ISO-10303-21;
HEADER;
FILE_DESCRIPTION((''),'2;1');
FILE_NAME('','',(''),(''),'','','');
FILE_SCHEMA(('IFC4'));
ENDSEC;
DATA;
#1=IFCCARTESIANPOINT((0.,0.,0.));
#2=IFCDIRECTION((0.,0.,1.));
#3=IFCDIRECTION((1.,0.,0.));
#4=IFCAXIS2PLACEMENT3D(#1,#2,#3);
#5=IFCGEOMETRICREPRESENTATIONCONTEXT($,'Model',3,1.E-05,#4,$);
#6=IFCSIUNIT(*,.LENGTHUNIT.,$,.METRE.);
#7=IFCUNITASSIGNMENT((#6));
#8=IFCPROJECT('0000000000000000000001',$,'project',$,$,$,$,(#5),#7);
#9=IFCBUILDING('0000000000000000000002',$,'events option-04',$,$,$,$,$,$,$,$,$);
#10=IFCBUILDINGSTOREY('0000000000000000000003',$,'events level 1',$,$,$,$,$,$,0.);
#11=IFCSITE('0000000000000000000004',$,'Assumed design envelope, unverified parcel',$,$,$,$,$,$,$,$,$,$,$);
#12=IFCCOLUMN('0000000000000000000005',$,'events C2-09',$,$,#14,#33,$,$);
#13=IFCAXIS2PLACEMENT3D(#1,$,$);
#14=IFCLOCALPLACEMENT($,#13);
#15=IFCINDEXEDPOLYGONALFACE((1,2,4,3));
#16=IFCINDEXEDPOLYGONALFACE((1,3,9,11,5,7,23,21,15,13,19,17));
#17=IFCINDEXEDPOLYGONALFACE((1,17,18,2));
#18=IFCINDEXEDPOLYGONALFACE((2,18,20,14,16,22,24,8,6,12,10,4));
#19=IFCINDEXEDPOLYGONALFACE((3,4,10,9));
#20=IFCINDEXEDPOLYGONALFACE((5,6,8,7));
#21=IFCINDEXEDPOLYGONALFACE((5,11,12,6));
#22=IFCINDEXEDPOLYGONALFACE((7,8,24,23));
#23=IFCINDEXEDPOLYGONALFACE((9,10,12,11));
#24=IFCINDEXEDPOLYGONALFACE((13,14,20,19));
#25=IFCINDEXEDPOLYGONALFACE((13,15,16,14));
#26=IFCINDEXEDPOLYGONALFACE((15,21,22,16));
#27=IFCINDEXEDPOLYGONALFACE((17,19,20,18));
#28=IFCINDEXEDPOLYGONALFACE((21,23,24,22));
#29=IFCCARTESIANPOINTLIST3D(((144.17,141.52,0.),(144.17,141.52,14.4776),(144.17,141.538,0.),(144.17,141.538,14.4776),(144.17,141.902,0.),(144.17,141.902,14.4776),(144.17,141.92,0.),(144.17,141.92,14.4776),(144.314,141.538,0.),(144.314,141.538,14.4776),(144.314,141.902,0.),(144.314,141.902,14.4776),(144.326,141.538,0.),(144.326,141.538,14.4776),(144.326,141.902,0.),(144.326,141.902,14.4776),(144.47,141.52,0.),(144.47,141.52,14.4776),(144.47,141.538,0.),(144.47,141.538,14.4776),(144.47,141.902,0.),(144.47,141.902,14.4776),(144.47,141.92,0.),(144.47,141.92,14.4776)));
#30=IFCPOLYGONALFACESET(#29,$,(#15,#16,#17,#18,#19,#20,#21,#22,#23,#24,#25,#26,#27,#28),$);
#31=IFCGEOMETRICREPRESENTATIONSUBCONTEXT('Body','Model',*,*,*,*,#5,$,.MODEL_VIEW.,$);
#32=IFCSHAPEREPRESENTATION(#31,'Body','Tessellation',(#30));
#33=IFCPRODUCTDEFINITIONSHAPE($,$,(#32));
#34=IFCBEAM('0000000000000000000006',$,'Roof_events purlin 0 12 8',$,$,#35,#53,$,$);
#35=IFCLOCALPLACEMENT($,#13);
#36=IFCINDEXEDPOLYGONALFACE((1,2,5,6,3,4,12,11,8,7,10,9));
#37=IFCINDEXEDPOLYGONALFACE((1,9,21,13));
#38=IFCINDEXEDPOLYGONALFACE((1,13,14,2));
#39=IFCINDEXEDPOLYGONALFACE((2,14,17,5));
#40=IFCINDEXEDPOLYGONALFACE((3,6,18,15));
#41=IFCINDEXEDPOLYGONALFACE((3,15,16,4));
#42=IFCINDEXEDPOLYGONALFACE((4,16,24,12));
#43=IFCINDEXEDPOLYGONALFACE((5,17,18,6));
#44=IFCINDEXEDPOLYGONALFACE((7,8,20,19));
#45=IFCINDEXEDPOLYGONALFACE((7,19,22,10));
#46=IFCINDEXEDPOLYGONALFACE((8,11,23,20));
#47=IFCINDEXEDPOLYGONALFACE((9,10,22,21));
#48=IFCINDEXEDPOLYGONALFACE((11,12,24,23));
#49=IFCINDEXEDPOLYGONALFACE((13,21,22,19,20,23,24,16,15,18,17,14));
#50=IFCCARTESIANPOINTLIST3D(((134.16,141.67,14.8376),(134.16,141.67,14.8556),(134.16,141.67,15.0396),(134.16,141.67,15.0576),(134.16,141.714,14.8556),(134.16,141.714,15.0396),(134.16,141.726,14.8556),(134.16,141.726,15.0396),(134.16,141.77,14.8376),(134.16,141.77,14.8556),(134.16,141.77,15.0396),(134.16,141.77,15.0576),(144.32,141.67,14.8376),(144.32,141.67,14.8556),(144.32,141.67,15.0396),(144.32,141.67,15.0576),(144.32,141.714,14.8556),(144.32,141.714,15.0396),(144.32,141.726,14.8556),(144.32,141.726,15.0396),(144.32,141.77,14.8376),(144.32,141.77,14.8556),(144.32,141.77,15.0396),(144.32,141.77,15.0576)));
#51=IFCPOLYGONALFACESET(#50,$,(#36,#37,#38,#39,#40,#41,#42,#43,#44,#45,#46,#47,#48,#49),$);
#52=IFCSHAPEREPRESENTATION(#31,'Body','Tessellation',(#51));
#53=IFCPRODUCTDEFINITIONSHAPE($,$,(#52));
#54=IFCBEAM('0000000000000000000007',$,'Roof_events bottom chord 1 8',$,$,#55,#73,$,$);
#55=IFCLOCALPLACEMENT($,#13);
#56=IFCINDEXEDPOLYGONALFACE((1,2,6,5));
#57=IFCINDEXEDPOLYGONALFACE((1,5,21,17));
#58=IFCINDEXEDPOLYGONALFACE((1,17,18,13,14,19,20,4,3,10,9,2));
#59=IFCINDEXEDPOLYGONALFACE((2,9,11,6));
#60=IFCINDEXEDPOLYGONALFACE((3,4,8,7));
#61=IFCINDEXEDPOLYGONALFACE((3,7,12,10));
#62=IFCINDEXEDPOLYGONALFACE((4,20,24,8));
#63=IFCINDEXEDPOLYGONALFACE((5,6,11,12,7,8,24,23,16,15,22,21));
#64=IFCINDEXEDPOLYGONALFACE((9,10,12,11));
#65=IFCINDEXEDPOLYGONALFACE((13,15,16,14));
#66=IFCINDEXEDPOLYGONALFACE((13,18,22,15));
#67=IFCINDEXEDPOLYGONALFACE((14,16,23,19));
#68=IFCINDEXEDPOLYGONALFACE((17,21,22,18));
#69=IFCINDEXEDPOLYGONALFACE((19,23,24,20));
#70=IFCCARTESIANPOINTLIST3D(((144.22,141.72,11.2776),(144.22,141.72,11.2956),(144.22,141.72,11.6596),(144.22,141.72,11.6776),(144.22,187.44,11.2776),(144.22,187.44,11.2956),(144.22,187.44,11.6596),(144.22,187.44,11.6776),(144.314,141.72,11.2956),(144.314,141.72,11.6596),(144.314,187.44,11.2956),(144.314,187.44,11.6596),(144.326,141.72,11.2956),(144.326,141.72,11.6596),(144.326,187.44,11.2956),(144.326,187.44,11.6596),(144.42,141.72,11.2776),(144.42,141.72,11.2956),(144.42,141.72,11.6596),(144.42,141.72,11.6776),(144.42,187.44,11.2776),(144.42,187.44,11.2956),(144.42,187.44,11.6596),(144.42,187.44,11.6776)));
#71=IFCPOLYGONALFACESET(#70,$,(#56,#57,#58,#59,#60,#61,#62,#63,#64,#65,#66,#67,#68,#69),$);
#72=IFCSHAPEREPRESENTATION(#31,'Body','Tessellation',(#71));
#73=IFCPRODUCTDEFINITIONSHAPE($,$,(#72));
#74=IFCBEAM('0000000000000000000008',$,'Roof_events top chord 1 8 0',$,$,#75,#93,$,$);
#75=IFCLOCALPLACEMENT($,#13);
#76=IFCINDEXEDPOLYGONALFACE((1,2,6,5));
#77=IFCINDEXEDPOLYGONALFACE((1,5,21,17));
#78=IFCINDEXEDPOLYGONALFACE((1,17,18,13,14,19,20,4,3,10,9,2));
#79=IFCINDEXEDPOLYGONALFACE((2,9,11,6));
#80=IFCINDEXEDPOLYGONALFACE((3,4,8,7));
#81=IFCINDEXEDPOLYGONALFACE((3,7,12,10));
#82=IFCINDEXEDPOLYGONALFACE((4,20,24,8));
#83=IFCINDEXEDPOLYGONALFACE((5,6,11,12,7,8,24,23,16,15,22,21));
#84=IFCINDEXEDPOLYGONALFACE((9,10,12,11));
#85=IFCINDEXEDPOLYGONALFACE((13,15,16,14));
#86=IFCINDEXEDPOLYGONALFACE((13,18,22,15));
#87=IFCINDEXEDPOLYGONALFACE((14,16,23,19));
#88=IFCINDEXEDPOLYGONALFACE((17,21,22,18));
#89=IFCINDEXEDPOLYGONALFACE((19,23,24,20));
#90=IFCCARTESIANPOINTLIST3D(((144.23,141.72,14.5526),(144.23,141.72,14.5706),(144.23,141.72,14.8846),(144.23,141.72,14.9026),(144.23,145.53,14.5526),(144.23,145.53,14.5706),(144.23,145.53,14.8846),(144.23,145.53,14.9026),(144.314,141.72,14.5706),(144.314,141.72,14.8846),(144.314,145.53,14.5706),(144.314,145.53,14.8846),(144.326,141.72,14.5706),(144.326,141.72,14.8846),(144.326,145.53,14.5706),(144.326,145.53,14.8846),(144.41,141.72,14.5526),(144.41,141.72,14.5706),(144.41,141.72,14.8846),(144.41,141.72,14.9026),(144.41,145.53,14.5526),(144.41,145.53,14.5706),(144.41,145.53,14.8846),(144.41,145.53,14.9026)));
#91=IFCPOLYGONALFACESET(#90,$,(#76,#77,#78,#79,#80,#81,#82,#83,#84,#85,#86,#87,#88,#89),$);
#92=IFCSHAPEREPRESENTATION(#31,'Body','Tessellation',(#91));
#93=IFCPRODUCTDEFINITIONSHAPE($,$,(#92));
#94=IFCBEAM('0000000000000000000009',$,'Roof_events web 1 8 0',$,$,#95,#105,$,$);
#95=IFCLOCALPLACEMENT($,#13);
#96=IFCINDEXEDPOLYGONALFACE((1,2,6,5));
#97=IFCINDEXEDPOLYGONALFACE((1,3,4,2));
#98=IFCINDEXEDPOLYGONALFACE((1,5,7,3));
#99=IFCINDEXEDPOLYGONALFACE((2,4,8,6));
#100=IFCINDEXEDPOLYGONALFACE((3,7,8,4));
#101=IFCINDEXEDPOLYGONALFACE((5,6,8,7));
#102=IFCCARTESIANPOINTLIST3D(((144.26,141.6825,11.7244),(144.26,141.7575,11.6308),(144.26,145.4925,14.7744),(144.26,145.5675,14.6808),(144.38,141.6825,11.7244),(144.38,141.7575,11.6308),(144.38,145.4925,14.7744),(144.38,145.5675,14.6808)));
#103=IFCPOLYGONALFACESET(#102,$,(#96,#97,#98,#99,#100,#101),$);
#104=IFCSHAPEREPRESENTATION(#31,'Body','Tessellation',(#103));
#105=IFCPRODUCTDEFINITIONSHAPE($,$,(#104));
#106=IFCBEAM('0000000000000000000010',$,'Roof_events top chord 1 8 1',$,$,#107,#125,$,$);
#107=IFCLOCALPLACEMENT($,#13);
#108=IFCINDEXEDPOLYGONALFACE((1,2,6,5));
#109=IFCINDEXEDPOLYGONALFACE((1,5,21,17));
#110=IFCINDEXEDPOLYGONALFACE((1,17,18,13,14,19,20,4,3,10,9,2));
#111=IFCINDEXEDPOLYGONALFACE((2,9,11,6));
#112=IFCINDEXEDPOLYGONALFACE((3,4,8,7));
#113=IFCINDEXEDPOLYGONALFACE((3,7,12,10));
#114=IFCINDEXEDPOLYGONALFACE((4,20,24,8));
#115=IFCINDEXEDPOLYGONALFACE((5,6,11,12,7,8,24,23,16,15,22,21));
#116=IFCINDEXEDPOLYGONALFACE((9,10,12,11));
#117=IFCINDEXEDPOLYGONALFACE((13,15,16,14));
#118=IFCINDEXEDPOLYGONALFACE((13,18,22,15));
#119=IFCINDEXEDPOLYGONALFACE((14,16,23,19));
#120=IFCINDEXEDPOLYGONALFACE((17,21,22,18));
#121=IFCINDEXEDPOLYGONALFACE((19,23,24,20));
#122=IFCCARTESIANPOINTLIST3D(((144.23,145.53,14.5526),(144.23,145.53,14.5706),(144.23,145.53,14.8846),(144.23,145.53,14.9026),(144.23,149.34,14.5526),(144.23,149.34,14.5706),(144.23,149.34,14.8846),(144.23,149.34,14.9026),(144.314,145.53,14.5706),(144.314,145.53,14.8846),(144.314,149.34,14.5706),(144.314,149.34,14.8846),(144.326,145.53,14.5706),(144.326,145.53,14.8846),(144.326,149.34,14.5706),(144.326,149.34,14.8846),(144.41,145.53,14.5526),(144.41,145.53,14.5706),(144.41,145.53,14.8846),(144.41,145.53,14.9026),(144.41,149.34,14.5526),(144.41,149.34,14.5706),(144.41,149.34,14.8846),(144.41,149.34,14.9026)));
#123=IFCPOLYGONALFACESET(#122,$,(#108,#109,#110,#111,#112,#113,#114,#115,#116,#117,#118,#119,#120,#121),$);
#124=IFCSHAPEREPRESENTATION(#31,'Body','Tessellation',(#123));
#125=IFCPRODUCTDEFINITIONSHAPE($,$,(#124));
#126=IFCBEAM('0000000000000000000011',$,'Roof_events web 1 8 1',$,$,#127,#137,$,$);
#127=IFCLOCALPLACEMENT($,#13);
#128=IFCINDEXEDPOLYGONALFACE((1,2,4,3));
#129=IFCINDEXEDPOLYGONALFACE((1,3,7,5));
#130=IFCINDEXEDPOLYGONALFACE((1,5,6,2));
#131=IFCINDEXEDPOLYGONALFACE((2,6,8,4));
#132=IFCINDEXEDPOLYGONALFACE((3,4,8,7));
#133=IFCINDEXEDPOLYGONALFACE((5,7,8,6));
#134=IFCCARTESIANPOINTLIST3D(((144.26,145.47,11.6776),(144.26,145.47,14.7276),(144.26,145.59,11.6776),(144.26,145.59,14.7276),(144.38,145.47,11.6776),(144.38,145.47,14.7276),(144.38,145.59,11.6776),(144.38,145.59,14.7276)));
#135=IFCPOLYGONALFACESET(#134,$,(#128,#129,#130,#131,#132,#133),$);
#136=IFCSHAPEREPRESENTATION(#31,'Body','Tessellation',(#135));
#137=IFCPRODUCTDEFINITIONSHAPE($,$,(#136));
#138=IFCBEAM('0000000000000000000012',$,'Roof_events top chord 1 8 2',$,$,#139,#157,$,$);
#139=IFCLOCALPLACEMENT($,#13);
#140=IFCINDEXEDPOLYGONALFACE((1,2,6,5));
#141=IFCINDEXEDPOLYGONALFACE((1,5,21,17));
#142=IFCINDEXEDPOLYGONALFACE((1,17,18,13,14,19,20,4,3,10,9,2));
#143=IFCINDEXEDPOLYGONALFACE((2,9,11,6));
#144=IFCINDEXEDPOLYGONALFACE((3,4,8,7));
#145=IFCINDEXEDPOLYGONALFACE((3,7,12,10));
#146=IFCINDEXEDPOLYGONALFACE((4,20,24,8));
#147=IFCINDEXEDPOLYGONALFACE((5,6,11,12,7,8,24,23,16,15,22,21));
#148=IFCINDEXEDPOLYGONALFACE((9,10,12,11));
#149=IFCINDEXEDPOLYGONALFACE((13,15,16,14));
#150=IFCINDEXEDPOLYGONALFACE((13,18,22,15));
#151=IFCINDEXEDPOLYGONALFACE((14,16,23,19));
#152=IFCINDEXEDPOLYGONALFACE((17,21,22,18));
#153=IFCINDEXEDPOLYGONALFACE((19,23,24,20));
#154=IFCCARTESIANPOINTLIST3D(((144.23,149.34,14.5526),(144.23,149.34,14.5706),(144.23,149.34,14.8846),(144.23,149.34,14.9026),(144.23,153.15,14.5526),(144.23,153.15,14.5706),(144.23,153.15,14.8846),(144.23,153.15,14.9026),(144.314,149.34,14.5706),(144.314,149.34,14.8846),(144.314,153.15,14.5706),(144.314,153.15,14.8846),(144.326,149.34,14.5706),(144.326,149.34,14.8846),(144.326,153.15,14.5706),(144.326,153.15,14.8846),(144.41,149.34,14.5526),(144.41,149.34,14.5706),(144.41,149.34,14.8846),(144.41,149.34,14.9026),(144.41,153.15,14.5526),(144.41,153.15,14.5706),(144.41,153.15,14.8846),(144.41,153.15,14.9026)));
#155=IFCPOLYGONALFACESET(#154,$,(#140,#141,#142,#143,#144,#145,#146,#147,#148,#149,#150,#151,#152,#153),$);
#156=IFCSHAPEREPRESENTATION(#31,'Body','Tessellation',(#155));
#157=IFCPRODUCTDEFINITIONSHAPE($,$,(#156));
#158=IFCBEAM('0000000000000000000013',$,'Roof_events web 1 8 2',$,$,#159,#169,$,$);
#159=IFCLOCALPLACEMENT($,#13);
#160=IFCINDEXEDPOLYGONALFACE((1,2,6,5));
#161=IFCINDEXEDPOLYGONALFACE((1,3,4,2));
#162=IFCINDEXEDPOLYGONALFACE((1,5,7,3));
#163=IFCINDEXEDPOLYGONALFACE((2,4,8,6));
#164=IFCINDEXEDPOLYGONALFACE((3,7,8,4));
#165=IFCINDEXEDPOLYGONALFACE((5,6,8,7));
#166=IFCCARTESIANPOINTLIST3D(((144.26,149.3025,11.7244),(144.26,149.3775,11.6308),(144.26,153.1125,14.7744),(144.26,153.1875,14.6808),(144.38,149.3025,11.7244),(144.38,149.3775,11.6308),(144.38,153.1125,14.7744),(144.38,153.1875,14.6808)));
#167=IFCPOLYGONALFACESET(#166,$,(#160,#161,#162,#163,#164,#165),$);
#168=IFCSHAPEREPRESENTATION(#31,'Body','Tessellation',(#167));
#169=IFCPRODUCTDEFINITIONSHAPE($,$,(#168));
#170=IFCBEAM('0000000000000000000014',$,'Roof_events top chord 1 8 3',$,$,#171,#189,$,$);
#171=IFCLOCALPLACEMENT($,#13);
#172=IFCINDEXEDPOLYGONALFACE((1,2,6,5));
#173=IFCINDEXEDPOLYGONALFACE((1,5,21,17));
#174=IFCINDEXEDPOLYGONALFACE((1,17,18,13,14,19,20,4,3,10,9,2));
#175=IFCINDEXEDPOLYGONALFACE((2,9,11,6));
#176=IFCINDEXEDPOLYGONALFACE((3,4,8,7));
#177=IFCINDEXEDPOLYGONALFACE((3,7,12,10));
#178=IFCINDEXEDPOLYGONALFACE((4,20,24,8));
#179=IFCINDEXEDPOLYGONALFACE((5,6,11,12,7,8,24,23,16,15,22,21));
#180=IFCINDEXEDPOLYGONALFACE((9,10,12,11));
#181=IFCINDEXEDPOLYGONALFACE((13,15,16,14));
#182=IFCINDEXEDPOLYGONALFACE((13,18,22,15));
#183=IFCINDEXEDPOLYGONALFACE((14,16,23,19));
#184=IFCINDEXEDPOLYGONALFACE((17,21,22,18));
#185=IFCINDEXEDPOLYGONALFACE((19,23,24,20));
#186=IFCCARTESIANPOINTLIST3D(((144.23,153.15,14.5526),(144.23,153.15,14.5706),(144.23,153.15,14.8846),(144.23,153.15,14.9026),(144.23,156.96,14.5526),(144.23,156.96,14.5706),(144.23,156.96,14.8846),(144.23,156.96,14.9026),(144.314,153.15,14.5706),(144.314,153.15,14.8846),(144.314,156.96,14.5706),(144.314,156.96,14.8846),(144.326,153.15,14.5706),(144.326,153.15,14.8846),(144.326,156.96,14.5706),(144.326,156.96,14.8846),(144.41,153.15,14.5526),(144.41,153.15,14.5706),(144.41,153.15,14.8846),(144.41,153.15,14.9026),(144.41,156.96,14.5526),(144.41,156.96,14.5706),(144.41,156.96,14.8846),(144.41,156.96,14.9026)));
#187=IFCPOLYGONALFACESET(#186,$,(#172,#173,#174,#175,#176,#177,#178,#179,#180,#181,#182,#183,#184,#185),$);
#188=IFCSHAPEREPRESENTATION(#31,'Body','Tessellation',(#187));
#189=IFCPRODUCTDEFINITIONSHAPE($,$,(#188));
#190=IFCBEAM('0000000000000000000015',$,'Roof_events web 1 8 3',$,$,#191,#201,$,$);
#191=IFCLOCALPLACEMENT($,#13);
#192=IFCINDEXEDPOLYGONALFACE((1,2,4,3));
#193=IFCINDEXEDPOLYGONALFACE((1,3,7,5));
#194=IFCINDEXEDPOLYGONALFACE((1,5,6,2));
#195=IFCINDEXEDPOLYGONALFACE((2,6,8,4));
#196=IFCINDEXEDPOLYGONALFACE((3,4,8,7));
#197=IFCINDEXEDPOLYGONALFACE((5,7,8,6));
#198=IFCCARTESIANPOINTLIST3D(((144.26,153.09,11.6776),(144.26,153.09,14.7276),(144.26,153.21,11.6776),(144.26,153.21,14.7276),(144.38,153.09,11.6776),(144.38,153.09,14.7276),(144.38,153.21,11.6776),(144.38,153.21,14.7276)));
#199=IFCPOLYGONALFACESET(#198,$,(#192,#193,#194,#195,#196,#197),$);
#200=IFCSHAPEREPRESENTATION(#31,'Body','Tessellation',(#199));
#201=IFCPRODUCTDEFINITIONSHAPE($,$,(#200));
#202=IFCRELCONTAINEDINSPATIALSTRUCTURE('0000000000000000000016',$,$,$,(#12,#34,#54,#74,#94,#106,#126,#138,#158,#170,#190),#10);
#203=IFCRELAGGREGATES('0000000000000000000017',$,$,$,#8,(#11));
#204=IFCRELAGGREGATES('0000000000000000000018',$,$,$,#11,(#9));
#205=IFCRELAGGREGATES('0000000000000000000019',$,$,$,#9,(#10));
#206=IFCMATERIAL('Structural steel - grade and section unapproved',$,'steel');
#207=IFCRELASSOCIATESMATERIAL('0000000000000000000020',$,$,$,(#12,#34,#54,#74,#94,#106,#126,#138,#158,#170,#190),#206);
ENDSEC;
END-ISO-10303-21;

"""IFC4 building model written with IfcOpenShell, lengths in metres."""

from ifc_helpers import new_model, si_unit, frame, origin_with_axes, place, context, subcontext, project, spatial, rectangle, i_section, extrude, material, element, save


model = new_model("IFC4")

# Units and contexts
model_context = context("Model", 3, precision=1e-05, world=origin_with_axes())
body_context = subcontext(model_context, "Body", "Model", "MODEL_VIEW")
ifc_project = project(units=[si_unit("LENGTHUNIT", "METRE")], contexts=[model_context])

# Site, building, storey
site = spatial("IfcSite", under=ifc_project, Name="Assumed design envelope, unverified parcel")
building = spatial("IfcBuilding", under=site, Name="events option-04")
storey = spatial("IfcBuildingStorey", under=building, Name="events level 1", Elevation=0.0)

# Column
ifc_material_1 = material(Name="Structural steel - grade and section unapproved", Category="steel")
column_placement = place(None, frame((144.32, 141.72, 0.0), z_axis=(0.0, 0.0, 1.0), x_axis=(-1.0, 0.0, 0.0)))
element("IfcColumn", 1, at=column_placement, inside=storey, material=ifc_material_1, Name="events C2-09", context=body_context, shape_type="SweptSolid", body=[
    extrude(i_section(OverallWidth=0.3, OverallDepth=0.4, WebThickness=0.012, FlangeThickness=0.018, FilletRadius=0.0), origin_with_axes(), (0.0, 0.0, 1.0), 14.4776),
])

# Beams
beam_1_placement = place(None, frame((144.32, 141.72, 14.9476), z_axis=(-1.0, 0.0, 0.0), x_axis=(0.0, -1.0, 0.0)))
element("IfcBeam", 2, at=beam_1_placement, inside=storey, material=ifc_material_1, Name="Roof_events purlin 0 12 8", context=body_context, shape_type="SweptSolid", body=[
    extrude(i_section(OverallWidth=0.1, OverallDepth=0.22, WebThickness=0.012, FlangeThickness=0.018, FilletRadius=0.0), origin_with_axes(), (0.0, 0.0, 1.0), 10.16),
])
beam_2_placement = place(None, frame((144.32, 141.72, 11.4776), z_axis=(0.0, 1.0, 0.0), x_axis=(-1.0, 0.0, 0.0)))
element("IfcBeam", 3, at=beam_2_placement, inside=storey, material=ifc_material_1, Name="Roof_events bottom chord 1 8", context=body_context, shape_type="SweptSolid", body=[
    extrude(i_section(OverallWidth=0.2, OverallDepth=0.4, WebThickness=0.012, FlangeThickness=0.018, FilletRadius=0.0), origin_with_axes(), (0.0, 0.0, 1.0), 45.72),
])
beam_3_placement = place(None, frame((144.32, 141.72, 14.7276), z_axis=(0.0, 1.0, 0.0), x_axis=(-1.0, 0.0, 0.0)))
element("IfcBeam", 4, at=beam_3_placement, inside=storey, material=ifc_material_1, Name="Roof_events top chord 1 8 0", context=body_context, shape_type="SweptSolid", body=[
    extrude(i_section(OverallWidth=0.18, OverallDepth=0.35, WebThickness=0.012, FlangeThickness=0.018, FilletRadius=0.0), origin_with_axes(), (0.0, 0.0, 1.0), 3.81),
])
beam_4_placement = place(None, frame((144.32, 141.72, 11.6776), z_axis=(0.0, 0.780669, 0.624945), x_axis=(-1.0, 0.0, 0.0)))
element("IfcBeam", 5, at=beam_4_placement, inside=storey, material=ifc_material_1, Name="Roof_events web 1 8 0", context=body_context, shape_type="SweptSolid", body=[
    extrude(rectangle(XDim=0.12, YDim=0.12), origin_with_axes(), (0.0, 0.0, 1.0), 4.8804),
])
beam_5_placement = place(None, frame((144.32, 145.53, 14.7276), z_axis=(0.0, 1.0, 0.0), x_axis=(-1.0, 0.0, 0.0)))
element("IfcBeam", 6, at=beam_5_placement, inside=storey, material=ifc_material_1, Name="Roof_events top chord 1 8 1", context=body_context, shape_type="SweptSolid", body=[
    extrude(i_section(OverallWidth=0.18, OverallDepth=0.35, WebThickness=0.012, FlangeThickness=0.018, FilletRadius=0.0), origin_with_axes(), (0.0, 0.0, 1.0), 3.81),
])
beam_6_placement = place(None, frame((144.32, 145.53, 11.6776), z_axis=(0.0, 0.0, 1.0), x_axis=(-1.0, 0.0, 0.0)))
element("IfcBeam", 7, at=beam_6_placement, inside=storey, material=ifc_material_1, Name="Roof_events web 1 8 1", context=body_context, shape_type="SweptSolid", body=[
    extrude(rectangle(XDim=0.12, YDim=0.12), origin_with_axes(), (0.0, 0.0, 1.0), 3.05),
])
beam_7_placement = place(None, frame((144.32, 149.34, 14.7276), z_axis=(0.0, 1.0, 0.0), x_axis=(-1.0, 0.0, 0.0)))
element("IfcBeam", 8, at=beam_7_placement, inside=storey, material=ifc_material_1, Name="Roof_events top chord 1 8 2", context=body_context, shape_type="SweptSolid", body=[
    extrude(i_section(OverallWidth=0.18, OverallDepth=0.35, WebThickness=0.012, FlangeThickness=0.018, FilletRadius=0.0), origin_with_axes(), (0.0, 0.0, 1.0), 3.81),
])
beam_8_placement = place(None, frame((144.32, 149.34, 11.6776), z_axis=(0.0, 0.780669, 0.624945), x_axis=(-1.0, 0.0, 0.0)))
element("IfcBeam", 9, at=beam_8_placement, inside=storey, material=ifc_material_1, Name="Roof_events web 1 8 2", context=body_context, shape_type="SweptSolid", body=[
    extrude(rectangle(XDim=0.12, YDim=0.12), origin_with_axes(), (0.0, 0.0, 1.0), 4.8804),
])
beam_9_placement = place(None, frame((144.32, 153.15, 14.7276), z_axis=(0.0, 1.0, 0.0), x_axis=(-1.0, 0.0, 0.0)))
element("IfcBeam", 10, at=beam_9_placement, inside=storey, material=ifc_material_1, Name="Roof_events top chord 1 8 3", context=body_context, shape_type="SweptSolid", body=[
    extrude(i_section(OverallWidth=0.18, OverallDepth=0.35, WebThickness=0.012, FlangeThickness=0.018, FilletRadius=0.0), origin_with_axes(), (0.0, 0.0, 1.0), 3.81),
])
beam_10_placement = place(None, frame((144.32, 153.15, 11.6776), z_axis=(0.0, 0.0, 1.0), x_axis=(-1.0, 0.0, 0.0)))
element("IfcBeam", 11, at=beam_10_placement, inside=storey, material=ifc_material_1, Name="Roof_events web 1 8 3", context=body_context, shape_type="SweptSolid", body=[
    extrude(rectangle(XDim=0.12, YDim=0.12), origin_with_axes(), (0.0, 0.0, 1.0), 3.05),
])

save(model, "model.ifc")
